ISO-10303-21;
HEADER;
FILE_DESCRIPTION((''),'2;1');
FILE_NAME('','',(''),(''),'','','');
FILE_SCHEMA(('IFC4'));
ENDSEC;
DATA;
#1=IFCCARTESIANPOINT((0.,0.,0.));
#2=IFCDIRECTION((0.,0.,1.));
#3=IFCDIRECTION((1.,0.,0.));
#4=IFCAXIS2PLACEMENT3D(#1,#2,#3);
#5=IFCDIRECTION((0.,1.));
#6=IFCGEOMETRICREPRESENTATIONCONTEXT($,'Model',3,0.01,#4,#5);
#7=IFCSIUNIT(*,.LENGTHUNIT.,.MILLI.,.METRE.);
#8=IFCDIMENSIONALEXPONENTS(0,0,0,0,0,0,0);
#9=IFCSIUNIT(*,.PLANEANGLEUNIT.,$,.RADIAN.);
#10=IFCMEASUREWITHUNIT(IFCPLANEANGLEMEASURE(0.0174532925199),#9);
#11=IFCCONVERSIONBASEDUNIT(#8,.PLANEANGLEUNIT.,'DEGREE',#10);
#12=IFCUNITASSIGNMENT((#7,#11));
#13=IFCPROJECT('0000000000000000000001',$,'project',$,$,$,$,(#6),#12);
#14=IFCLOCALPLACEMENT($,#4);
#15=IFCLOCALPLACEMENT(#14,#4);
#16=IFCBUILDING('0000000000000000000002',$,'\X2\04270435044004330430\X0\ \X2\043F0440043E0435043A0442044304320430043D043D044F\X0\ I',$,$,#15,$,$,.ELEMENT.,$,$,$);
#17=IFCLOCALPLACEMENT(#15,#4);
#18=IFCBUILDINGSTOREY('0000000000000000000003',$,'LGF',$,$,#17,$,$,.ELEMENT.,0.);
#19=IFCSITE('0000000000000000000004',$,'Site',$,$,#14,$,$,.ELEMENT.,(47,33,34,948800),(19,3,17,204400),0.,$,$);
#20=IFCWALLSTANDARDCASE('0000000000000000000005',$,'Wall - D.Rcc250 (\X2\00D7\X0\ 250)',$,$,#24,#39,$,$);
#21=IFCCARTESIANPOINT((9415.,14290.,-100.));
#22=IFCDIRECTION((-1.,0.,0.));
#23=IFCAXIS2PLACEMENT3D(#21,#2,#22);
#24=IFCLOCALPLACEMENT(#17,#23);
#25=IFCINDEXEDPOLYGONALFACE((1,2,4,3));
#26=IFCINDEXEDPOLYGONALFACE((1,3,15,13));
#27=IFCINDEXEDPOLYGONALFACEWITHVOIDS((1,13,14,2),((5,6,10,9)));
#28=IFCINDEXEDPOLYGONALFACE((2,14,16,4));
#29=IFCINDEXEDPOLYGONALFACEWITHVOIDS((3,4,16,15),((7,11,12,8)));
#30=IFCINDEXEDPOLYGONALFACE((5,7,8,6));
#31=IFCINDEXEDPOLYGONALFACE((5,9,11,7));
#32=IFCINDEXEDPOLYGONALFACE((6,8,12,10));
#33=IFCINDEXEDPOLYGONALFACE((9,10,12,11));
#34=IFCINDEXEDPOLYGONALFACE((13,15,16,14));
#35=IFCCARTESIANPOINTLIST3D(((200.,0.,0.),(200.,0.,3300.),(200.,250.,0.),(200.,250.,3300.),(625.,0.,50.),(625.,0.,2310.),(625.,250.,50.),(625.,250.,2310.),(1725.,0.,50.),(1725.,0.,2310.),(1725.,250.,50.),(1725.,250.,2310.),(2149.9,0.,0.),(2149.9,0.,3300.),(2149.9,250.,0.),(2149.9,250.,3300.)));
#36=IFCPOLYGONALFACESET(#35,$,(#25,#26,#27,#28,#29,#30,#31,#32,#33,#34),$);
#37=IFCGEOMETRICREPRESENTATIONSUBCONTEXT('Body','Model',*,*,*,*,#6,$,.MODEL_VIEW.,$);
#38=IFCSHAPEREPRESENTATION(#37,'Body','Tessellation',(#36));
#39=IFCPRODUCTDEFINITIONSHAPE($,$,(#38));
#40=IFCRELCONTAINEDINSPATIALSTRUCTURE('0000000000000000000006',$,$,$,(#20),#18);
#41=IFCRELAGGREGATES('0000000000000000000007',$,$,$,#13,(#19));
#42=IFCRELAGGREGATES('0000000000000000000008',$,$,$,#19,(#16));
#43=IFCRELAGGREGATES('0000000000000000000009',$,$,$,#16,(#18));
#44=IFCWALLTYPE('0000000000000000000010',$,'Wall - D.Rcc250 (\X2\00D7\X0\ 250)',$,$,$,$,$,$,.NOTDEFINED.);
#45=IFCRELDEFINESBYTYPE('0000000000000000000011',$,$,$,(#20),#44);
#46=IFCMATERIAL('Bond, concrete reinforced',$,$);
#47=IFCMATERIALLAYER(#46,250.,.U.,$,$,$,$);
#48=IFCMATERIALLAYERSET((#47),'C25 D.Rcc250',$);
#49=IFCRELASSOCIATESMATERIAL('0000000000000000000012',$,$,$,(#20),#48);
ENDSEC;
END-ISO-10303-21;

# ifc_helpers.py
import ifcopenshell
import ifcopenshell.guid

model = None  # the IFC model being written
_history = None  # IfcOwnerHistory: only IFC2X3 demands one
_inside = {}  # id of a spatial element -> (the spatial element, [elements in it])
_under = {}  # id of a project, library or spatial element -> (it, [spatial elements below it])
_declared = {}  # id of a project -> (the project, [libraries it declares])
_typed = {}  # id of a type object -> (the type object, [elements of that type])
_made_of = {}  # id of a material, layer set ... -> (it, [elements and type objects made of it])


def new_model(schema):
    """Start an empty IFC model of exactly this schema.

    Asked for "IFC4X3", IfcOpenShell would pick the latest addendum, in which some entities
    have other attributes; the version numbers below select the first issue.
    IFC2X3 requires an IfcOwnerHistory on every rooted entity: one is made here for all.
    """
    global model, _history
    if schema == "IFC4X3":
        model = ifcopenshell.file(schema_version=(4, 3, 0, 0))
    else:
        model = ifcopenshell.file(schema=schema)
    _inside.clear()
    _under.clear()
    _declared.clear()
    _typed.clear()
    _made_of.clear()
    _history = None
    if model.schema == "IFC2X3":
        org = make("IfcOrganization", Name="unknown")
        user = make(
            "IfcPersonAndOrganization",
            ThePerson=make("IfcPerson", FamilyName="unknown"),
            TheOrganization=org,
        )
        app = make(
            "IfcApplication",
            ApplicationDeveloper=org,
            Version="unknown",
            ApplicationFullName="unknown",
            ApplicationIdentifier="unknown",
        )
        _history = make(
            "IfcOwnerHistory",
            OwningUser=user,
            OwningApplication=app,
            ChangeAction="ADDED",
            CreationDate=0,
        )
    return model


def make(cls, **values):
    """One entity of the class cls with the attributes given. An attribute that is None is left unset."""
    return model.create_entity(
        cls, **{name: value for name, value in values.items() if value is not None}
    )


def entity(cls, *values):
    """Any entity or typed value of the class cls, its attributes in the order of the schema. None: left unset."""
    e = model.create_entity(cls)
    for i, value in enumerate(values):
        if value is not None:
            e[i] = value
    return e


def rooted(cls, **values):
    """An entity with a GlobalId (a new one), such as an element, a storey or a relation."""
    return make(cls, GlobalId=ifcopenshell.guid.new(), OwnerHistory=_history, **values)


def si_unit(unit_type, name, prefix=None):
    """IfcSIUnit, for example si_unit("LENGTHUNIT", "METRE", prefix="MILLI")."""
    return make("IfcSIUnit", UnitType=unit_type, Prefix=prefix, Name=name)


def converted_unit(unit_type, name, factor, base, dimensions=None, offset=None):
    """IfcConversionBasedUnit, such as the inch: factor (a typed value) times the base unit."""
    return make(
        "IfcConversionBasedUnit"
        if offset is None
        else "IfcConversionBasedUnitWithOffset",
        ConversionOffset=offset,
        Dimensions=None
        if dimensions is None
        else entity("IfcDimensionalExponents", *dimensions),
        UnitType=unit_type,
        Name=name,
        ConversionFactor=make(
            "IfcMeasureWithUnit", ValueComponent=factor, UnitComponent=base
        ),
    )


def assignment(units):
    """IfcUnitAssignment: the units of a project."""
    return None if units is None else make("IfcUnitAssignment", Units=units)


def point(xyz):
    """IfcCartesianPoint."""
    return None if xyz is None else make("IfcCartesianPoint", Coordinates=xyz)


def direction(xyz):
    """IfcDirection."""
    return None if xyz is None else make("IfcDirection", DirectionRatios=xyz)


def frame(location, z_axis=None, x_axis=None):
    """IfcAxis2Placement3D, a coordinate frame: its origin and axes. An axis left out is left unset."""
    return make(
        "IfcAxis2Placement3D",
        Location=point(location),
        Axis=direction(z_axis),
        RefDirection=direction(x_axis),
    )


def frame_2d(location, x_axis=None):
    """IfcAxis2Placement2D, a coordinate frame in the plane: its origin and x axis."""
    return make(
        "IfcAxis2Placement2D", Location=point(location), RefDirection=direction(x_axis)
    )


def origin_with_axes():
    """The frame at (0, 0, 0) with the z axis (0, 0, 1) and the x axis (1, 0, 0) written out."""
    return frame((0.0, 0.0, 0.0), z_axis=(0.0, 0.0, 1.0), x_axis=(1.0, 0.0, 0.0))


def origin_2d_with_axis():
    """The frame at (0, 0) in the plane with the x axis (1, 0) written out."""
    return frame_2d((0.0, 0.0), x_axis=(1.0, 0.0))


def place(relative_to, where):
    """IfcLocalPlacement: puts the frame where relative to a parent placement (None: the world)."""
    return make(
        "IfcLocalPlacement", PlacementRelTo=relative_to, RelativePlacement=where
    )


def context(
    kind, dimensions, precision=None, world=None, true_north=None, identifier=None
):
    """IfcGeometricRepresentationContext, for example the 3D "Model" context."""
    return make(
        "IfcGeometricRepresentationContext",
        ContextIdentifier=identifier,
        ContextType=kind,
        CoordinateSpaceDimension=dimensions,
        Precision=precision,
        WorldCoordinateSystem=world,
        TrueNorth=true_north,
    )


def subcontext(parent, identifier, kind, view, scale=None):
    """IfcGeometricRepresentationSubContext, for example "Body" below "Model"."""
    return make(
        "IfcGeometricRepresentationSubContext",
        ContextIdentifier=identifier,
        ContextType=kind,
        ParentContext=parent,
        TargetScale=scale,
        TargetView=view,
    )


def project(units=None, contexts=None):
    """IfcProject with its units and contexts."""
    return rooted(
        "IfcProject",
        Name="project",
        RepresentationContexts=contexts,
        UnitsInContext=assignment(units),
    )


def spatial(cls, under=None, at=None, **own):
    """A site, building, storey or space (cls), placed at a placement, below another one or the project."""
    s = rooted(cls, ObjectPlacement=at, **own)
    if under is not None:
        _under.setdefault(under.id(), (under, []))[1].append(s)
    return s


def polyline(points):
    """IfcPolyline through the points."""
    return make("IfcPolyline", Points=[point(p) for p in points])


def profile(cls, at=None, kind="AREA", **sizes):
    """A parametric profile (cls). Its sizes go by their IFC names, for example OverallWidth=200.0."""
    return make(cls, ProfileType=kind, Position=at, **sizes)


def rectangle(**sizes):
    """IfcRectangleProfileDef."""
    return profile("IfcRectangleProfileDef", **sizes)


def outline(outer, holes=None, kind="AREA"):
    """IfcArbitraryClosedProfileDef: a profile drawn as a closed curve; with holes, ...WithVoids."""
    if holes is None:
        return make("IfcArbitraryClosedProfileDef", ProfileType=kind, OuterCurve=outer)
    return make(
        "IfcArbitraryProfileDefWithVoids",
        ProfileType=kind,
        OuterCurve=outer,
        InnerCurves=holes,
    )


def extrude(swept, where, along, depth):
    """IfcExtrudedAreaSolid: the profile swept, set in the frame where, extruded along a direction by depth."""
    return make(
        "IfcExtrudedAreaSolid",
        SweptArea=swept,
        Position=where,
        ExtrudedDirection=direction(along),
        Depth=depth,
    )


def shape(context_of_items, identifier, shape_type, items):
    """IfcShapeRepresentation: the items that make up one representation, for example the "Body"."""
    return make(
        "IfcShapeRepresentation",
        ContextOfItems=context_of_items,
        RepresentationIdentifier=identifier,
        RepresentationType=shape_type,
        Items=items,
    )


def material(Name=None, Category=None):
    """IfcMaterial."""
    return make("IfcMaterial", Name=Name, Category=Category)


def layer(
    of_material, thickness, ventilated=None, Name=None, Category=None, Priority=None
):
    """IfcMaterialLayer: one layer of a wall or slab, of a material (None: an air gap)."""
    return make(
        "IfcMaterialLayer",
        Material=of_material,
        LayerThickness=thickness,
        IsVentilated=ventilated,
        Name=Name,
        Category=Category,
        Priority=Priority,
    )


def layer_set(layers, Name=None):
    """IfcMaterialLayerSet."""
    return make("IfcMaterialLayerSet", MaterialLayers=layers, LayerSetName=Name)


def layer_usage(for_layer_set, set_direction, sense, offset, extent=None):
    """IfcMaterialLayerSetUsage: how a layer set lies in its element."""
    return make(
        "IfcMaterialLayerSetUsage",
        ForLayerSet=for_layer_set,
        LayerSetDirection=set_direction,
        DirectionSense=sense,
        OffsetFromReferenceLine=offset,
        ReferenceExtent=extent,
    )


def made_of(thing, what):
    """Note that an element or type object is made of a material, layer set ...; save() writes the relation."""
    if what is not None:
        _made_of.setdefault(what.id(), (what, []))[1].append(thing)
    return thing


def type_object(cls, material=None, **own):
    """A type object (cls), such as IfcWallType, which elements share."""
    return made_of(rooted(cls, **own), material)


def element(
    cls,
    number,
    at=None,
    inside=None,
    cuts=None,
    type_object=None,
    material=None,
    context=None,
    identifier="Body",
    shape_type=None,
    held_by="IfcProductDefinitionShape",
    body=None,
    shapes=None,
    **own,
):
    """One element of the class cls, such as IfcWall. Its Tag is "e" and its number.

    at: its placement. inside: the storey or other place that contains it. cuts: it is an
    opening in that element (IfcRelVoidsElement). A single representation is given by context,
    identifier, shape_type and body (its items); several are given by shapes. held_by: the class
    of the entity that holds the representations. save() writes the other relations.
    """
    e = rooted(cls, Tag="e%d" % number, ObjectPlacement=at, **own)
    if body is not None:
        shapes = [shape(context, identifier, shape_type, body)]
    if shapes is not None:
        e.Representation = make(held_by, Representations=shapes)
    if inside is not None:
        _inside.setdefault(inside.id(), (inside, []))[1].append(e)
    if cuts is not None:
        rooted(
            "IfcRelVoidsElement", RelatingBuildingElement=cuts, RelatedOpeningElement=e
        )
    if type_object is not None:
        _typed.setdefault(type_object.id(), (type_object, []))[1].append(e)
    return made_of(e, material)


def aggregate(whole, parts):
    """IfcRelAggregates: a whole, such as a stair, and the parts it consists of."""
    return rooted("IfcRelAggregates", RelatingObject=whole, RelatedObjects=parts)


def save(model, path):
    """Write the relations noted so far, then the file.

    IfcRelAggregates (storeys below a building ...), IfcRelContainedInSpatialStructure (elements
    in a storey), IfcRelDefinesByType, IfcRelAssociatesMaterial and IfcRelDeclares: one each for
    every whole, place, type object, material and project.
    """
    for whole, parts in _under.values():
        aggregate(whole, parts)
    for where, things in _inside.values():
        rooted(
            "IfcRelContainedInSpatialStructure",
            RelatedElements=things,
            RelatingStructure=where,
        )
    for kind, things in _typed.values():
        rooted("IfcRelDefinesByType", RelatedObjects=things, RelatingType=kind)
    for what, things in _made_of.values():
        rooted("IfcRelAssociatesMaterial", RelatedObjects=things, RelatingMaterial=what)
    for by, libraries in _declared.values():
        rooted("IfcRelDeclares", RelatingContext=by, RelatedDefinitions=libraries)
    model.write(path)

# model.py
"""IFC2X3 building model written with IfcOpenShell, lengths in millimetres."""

from ifc_helpers import new_model, entity, si_unit, converted_unit, direction, frame, origin_with_axes, origin_2d_with_axis, place, context, subcontext, project, spatial, polyline, rectangle, outline, extrude, material, layer, layer_set, layer_usage, type_object, element, save


model = new_model("IFC2X3")

# Units and contexts
model_context = context("Model", 3, precision=0.01, world=origin_with_axes(), true_north=direction((0.0, 1.0)))
body_context = subcontext(model_context, "Body", "Model", "MODEL_VIEW")
ifc_project = project(units=[si_unit("LENGTHUNIT", "METRE", prefix="MILLI"), converted_unit("PLANEANGLEUNIT", "DEGREE", entity("IfcPlaneAngleMeasure", 0.0174532925199), si_unit("PLANEANGLEUNIT", "RADIAN"), dimensions=[0, 0, 0, 0, 0, 0, 0])], contexts=[model_context])

# Site, building, storey
site_placement = place(None, origin_with_axes())
site = spatial("IfcSite", under=ifc_project, at=site_placement, Name="Site", CompositionType="ELEMENT", RefLatitude=(47, 33, 34, 948800), RefLongitude=(19, 3, 17, 204400), RefElevation=0.0)
building_placement = place(site_placement, origin_with_axes())
building = spatial("IfcBuilding", under=site, at=building_placement, Name="Черга проектування I", CompositionType="ELEMENT")
storey_placement = place(building_placement, origin_with_axes())
storey = spatial("IfcBuildingStorey", under=building, at=storey_placement, Name="LGF", CompositionType="ELEMENT", Elevation=0.0)

# Shared definitions
ifc_material = material(Name="Bond, concrete reinforced")

# Shared definitions
ifc_layer_1 = layer(ifc_material, 250.0, ventilated="UNKNOWN")
ifc_layer_set_1 = layer_set([ifc_layer_1], Name="C25 D.Rcc250")
wall_type_1 = type_object("IfcWallType", Name="Wall - D.Rcc250 (× 250)", PredefinedType="NOTDEFINED")

# Wall, opening
ifc_layer_usage_1 = layer_usage(ifc_layer_set_1, "AXIS2", "NEGATIVE", 250.0)
wall_1_placement = place(storey_placement, frame((9415.0, 14290.0, -100.0), z_axis=(0.0, 0.0, 1.0), x_axis=(-1.0, 0.0, 0.0)))
wall_1 = element("IfcWallStandardCase", 1, at=wall_1_placement, inside=storey, type_object=wall_type_1, material=ifc_layer_usage_1, Name="Wall - D.Rcc250 (× 250)", context=body_context, shape_type="SweptSolid", body=[
    extrude(outline(polyline([(200.0, 0.0), (2149.9, 0.0), (2149.9, 250.0), (200.0, 250.0), (200.0, 0.0)])), origin_with_axes(), (0.0, 0.0, 1.0), 3300.0),
])
opening_1_placement = place(wall_1_placement, frame((1175.0, 0.0, 50.0), z_axis=(0.0, 0.0, 1.0), x_axis=(1.0, 0.0, 0.0)))
element("IfcOpeningElement", 2, at=opening_1_placement, cuts=wall_1, context=body_context, shape_type="SweptSolid", body=[
    extrude(rectangle(XDim=1100.0, YDim=2260.0, at=origin_2d_with_axis()), frame((0.0, 0.0, 1130.0), z_axis=(0.0, 1.0, 0.0), x_axis=(1.0, 0.0, 0.0)), (0.0, 0.0, -1.0), 250.0),
    extrude(rectangle(XDim=1100.0, YDim=2260.0, at=origin_2d_with_axis()), frame((0.0, 0.0, 1130.0), z_axis=(0.0, -1.0, 0.0), x_axis=(1.0, 0.0, 0.0)), (0.0, 0.0, -1.0), 250.0),
])

save(model, "model.ifc")
